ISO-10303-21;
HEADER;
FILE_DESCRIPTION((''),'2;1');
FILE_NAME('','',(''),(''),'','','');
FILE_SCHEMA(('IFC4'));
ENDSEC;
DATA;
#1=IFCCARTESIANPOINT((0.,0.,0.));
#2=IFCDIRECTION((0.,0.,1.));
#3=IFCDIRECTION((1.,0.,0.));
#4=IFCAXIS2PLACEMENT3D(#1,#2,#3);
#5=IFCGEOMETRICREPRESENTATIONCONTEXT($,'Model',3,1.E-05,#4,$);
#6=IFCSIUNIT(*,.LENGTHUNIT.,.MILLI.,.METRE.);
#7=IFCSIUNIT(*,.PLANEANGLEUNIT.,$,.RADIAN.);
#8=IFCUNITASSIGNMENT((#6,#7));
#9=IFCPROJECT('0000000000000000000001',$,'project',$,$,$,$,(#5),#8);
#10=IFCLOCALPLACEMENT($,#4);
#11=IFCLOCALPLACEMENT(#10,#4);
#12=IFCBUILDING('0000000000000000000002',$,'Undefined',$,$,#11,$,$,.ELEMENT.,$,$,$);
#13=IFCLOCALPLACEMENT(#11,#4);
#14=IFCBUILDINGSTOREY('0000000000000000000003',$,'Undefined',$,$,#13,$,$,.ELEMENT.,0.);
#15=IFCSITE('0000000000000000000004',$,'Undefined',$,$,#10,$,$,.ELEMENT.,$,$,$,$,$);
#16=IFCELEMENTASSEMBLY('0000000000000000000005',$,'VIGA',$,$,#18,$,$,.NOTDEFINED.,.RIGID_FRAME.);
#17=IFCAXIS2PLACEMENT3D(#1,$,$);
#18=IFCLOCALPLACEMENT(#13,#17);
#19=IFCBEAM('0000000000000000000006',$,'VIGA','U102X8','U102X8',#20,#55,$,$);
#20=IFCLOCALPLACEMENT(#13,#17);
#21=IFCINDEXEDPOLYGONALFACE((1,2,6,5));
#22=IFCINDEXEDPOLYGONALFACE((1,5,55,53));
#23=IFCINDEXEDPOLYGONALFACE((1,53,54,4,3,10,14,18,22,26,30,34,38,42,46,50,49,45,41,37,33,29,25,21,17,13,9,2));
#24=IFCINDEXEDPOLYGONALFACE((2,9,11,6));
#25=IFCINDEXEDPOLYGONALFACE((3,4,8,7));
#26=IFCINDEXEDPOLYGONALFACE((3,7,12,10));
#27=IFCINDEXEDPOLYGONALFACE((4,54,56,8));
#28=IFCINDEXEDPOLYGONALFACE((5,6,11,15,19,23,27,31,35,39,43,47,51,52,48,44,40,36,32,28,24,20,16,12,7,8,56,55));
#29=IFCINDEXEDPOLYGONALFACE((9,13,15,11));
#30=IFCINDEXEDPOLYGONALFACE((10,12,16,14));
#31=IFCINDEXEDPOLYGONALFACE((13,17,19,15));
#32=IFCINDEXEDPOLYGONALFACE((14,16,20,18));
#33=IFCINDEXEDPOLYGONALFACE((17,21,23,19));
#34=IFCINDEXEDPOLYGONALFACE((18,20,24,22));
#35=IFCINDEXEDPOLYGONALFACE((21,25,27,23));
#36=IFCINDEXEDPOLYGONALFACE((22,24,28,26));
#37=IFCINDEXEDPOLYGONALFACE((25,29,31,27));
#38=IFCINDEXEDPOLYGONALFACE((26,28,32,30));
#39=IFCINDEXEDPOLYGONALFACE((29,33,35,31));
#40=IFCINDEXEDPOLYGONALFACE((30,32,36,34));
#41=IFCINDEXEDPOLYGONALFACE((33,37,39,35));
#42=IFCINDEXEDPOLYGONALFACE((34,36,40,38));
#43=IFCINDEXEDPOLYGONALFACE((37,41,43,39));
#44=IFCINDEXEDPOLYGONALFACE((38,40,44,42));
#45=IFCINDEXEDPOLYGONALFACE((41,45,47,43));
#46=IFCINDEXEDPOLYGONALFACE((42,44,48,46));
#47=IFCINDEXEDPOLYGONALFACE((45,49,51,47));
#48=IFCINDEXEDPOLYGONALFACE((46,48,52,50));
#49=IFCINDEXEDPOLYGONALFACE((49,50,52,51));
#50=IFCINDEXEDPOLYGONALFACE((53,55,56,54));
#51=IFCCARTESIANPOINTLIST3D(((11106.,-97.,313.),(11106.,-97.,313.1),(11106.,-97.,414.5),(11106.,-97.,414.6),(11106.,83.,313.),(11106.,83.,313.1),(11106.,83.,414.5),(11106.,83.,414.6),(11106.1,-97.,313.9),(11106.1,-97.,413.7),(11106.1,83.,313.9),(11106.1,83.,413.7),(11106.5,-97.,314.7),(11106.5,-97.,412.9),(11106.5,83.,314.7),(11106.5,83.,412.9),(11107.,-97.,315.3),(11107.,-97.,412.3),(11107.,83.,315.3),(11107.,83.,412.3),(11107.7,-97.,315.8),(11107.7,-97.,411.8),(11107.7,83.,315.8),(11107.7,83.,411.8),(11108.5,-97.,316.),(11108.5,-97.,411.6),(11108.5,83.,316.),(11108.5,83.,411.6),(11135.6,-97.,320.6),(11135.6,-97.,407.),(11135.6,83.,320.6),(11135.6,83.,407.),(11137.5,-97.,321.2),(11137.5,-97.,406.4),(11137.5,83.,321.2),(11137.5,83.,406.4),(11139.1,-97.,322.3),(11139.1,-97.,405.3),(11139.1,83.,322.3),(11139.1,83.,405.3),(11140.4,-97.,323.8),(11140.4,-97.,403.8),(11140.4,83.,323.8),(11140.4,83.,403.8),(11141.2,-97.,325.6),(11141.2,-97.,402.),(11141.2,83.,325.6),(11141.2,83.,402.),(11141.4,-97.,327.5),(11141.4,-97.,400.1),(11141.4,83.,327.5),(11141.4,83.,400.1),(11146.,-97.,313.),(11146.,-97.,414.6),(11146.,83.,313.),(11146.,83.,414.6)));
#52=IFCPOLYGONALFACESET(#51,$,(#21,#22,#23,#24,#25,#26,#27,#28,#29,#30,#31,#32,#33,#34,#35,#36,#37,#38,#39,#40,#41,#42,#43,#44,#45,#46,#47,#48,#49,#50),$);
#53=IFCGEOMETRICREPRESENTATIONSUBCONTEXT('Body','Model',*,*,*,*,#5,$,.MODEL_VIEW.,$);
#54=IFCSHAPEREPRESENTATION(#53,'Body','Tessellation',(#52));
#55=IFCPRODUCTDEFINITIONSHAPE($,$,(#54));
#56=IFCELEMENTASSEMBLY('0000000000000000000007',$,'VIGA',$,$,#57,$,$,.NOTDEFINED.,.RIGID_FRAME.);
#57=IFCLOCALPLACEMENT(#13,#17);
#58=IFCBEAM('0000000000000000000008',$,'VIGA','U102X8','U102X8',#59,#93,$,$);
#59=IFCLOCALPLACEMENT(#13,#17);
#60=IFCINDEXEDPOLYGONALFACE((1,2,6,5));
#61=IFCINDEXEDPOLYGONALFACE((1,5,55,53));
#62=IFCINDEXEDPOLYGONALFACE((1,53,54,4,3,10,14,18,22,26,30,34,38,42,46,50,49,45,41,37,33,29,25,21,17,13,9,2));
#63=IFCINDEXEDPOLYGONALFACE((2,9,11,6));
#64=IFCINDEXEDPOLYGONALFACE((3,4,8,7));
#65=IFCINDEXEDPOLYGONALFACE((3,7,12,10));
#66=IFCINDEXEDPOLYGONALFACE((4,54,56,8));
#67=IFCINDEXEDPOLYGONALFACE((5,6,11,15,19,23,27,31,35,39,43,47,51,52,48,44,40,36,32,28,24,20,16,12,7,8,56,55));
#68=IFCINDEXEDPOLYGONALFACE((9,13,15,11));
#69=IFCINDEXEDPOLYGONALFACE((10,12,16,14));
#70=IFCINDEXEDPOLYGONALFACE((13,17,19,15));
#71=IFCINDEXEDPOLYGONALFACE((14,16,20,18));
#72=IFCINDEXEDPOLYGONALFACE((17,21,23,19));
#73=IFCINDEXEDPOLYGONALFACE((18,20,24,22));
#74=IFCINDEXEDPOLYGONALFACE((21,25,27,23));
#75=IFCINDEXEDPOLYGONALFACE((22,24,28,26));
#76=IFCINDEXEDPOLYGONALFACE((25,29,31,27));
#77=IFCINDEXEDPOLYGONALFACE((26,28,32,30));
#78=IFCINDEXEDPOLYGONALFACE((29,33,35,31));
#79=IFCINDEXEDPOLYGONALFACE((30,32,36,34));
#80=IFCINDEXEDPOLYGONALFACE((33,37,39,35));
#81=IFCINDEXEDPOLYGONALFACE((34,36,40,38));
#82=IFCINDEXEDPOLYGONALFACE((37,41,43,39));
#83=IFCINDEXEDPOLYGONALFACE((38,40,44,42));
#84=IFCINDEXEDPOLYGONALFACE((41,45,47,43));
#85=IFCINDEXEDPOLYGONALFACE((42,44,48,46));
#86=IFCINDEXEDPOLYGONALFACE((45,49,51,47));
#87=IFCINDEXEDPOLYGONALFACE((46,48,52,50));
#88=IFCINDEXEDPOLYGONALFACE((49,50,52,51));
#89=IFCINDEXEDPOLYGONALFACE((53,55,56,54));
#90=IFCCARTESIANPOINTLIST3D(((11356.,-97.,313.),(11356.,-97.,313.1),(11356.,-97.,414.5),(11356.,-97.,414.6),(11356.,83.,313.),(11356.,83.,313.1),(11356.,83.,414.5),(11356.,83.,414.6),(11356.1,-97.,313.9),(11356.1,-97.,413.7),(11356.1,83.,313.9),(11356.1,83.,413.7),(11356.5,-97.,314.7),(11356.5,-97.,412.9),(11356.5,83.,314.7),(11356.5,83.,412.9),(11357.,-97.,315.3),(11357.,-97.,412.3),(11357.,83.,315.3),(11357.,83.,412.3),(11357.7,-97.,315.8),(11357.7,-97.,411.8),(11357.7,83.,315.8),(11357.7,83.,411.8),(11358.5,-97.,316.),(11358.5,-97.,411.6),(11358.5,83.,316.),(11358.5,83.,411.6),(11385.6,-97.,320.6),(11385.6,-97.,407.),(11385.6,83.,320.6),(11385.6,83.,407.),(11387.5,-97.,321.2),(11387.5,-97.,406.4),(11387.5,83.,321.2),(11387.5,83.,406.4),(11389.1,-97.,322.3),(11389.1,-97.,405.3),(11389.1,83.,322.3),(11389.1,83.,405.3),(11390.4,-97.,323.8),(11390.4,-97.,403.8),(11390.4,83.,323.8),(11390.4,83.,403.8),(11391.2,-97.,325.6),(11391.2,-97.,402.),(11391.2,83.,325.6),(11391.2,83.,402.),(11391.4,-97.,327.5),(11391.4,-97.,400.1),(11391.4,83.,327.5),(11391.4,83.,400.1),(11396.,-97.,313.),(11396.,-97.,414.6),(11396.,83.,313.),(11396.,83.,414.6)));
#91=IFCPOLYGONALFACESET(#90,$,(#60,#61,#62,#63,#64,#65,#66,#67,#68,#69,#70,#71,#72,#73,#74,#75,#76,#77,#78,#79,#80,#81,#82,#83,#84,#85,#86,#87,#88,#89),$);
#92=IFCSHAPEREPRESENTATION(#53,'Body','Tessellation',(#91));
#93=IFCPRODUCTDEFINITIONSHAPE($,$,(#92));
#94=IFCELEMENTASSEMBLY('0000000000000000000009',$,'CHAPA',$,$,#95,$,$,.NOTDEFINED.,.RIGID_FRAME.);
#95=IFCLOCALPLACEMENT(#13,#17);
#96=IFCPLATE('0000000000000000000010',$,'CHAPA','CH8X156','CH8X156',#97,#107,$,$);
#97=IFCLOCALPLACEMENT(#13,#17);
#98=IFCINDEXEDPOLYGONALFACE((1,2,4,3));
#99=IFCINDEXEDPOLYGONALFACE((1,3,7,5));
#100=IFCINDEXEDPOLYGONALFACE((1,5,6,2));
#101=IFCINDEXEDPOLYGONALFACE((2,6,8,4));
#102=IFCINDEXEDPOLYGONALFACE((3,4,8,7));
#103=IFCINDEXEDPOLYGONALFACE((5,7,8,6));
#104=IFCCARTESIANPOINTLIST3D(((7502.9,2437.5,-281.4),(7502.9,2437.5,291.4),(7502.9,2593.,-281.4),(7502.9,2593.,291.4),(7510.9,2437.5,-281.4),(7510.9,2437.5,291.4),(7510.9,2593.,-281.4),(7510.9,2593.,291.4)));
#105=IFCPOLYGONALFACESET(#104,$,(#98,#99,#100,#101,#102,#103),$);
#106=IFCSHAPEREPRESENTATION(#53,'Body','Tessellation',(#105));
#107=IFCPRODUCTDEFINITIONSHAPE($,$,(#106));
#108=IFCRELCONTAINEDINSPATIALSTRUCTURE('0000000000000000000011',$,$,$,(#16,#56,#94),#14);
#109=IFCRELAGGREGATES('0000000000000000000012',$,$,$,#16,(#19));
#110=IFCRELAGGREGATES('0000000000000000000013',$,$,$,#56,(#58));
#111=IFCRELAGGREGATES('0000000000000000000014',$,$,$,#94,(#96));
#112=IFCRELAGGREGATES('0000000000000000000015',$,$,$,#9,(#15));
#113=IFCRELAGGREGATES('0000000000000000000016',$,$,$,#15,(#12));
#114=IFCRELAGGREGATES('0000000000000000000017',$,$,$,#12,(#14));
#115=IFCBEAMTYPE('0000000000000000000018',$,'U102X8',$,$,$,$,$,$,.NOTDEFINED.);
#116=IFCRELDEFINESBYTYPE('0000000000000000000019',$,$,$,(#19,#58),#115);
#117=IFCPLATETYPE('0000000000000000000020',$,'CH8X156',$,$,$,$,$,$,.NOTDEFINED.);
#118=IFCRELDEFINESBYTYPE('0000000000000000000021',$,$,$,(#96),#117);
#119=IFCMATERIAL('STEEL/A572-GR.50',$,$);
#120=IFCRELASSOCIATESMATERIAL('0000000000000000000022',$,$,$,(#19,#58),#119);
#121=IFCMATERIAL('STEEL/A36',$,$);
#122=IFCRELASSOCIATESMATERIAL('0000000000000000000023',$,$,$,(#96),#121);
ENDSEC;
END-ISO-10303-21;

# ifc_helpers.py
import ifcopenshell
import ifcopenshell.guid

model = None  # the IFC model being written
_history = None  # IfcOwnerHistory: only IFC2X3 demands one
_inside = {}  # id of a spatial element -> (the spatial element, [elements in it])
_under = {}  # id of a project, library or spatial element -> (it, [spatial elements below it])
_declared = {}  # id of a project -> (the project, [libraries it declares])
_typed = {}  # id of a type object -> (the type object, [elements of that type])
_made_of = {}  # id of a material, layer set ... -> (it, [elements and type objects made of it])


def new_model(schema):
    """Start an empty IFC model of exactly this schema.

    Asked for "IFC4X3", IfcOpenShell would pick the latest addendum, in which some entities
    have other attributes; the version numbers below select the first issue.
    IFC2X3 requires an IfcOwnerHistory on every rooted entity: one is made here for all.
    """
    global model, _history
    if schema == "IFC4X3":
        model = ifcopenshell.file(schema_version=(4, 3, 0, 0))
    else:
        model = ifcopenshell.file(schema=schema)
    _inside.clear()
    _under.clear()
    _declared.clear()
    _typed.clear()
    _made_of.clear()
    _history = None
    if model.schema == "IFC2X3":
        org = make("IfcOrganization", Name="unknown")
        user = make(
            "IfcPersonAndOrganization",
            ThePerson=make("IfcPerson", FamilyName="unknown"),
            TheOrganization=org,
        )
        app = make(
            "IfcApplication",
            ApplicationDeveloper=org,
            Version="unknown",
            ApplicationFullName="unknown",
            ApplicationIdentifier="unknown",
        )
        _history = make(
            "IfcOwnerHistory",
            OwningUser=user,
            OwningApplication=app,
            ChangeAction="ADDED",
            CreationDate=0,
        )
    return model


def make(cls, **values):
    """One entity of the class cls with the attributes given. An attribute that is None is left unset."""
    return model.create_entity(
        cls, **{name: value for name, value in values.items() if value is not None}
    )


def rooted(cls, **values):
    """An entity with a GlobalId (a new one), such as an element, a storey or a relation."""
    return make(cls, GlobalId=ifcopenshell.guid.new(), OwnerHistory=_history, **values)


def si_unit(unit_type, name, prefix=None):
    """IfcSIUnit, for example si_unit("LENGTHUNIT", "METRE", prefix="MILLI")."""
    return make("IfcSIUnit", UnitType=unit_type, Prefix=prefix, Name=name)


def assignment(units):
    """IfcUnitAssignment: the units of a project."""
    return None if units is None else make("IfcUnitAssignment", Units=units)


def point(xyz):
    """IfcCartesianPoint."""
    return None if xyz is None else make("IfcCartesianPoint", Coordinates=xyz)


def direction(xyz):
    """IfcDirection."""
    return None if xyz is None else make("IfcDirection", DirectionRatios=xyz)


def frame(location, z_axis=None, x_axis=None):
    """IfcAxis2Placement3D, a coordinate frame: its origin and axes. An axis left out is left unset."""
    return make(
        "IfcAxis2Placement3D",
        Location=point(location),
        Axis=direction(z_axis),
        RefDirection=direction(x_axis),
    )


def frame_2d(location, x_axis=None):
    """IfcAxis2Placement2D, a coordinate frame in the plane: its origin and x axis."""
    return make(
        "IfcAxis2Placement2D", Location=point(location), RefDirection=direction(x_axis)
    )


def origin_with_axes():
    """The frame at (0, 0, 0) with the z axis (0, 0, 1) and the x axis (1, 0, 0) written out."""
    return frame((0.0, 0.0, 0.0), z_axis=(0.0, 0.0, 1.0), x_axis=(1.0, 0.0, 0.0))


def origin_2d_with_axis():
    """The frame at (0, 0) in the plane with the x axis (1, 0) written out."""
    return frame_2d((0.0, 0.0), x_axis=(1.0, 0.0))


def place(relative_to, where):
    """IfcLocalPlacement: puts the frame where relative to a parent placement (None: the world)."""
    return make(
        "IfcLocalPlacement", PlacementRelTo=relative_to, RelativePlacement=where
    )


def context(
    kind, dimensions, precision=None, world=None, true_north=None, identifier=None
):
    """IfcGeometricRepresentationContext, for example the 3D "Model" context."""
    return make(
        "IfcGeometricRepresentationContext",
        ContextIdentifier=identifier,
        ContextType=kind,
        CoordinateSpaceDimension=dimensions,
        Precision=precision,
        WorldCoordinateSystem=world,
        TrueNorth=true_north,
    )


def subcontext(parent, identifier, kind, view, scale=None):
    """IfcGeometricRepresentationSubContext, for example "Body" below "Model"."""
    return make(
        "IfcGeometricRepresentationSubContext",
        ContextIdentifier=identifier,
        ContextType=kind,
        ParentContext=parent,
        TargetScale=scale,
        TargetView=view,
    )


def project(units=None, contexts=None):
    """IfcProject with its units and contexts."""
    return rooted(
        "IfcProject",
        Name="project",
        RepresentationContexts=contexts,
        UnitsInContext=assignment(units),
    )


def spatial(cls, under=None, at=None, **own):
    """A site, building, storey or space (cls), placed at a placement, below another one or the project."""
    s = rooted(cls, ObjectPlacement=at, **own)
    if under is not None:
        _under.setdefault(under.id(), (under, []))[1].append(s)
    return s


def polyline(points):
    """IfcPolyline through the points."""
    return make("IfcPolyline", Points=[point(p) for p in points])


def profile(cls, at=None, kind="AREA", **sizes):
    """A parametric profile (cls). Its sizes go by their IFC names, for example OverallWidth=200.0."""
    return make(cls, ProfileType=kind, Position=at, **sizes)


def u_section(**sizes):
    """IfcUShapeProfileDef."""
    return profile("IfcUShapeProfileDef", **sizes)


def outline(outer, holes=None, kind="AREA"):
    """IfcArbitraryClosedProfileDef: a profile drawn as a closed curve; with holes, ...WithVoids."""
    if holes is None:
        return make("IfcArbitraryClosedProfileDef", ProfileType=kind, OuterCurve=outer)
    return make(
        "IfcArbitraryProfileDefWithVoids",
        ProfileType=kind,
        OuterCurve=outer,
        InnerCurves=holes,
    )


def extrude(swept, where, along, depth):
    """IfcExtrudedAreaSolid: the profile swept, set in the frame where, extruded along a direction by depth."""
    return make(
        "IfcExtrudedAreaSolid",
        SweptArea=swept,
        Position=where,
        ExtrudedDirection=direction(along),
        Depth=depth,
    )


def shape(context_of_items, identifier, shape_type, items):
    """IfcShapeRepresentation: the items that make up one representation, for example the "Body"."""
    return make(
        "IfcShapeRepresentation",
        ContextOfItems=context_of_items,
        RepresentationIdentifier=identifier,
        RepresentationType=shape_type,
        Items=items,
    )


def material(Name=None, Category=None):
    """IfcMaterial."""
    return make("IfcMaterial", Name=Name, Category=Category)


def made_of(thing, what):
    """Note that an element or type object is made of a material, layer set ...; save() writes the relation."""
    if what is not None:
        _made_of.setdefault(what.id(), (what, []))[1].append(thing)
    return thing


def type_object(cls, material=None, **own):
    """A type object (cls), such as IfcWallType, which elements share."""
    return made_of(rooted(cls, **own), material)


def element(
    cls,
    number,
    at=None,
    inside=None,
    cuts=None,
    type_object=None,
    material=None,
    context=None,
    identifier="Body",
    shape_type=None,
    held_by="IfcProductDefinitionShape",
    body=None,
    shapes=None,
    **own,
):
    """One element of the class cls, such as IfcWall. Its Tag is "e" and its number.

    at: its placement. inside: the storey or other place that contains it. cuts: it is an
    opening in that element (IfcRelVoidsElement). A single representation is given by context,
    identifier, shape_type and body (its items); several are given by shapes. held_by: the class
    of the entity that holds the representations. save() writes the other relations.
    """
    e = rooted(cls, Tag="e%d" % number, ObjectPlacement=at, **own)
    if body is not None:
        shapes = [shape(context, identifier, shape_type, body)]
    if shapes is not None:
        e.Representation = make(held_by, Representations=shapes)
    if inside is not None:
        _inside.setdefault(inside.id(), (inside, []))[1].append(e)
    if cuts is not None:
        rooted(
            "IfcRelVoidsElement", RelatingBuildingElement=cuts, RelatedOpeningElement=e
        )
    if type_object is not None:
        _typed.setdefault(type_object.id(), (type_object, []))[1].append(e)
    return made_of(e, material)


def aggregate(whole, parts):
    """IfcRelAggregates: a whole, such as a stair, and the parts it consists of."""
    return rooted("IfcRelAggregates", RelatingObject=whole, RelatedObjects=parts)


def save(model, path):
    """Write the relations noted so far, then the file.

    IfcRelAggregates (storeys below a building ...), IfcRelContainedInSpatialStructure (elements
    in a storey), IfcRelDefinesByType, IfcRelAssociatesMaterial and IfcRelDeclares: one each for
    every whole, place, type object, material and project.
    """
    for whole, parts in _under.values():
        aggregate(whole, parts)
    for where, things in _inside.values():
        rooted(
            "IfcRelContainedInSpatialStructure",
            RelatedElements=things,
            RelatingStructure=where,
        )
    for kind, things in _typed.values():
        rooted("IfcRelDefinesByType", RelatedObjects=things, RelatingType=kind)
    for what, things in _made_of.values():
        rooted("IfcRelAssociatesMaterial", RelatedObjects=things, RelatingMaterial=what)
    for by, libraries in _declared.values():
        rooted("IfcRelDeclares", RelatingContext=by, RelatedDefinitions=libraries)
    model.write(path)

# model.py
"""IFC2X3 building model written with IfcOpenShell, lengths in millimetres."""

from ifc_helpers import new_model, si_unit, frame, origin_with_axes, origin_2d_with_axis, place, context, subcontext, project, spatial, polyline, u_section, outline, extrude, material, type_object, element, aggregate, save


model = new_model("IFC2X3")

# Units and contexts
model_context = context("Model", 3, precision=1e-05, world=origin_with_axes())
body_context = subcontext(model_context, "Body", "Model", "MODEL_VIEW")
ifc_project = project(units=[si_unit("LENGTHUNIT", "METRE", prefix="MILLI"), si_unit("PLANEANGLEUNIT", "RADIAN")], contexts=[model_context])

# Site, building, storey
site_placement = place(None, origin_with_axes())
site = spatial("IfcSite", under=ifc_project, at=site_placement, Name="Undefined", CompositionType="ELEMENT")
building_placement = place(site_placement, origin_with_axes())
building = spatial("IfcBuilding", under=site, at=building_placement, Name="Undefined", CompositionType="ELEMENT")
storey_placement = place(building_placement, origin_with_axes())
storey = spatial("IfcBuildingStorey", under=building, at=storey_placement, Name="Undefined", CompositionType="ELEMENT", Elevation=0.0)

# Element assemblies, beams
ifc_material_1 = material(Name="STEEL/A572-GR.50")
beam_type = type_object("IfcBeamType", Name="U102X8", PredefinedType="NOTDEFINED")
assembly_1_placement = place(storey_placement, origin_with_axes())
assembly_1 = element("IfcElementAssembly", 1, at=assembly_1_placement, inside=storey, Name="VIGA", AssemblyPlace="NOTDEFINED", PredefinedType="RIGID_FRAME")
beam_1_placement = place(assembly_1_placement, frame((11126.0, 83.0, 363.8), z_axis=(0.0, 0.0, 1.0), x_axis=(0.0, -1.0, 0.0)))
beam_1 = element("IfcBeam", 2, at=beam_1_placement, type_object=beam_type, material=ifc_material_1, Name="VIGA", Description="U102X8", ObjectType="U102X8", context=body_context, shape_type="SweptSolid", body=[
    extrude(u_section(Depth=101.6, FlangeWidth=40.0, WebThickness=4.6, FlangeThickness=6.0, FilletRadius=7.0, EdgeRadius=3.0, FlangeSlope=0.16839, at=origin_2d_with_axis()), frame((180.0, 0.0, 0.0), z_axis=(-1.0, 0.0, 0.0), x_axis=(0.0, -1.0, 0.0)), (0.0, 0.0, 1.0), 180.0),
])
aggregate(assembly_1, [beam_1])
assembly_2_placement = place(storey_placement, origin_with_axes())
assembly_2 = element("IfcElementAssembly", 3, at=assembly_2_placement, inside=storey, Name="VIGA", AssemblyPlace="NOTDEFINED", PredefinedType="RIGID_FRAME")
beam_2_placement = place(assembly_2_placement, frame((11376.0, 83.0, 363.8), z_axis=(0.0, 0.0, 1.0), x_axis=(0.0, -1.0, 0.0)))
beam_2 = element("IfcBeam", 4, at=beam_2_placement, type_object=beam_type, material=ifc_material_1, Name="VIGA", Description="U102X8", ObjectType="U102X8", context=body_context, shape_type="SweptSolid", body=[
    extrude(u_section(Depth=101.6, FlangeWidth=40.0, WebThickness=4.6, FlangeThickness=6.0, FilletRadius=7.0, EdgeRadius=3.0, FlangeSlope=0.16839, at=origin_2d_with_axis()), frame((180.0, 0.0, 0.0), z_axis=(-1.0, 0.0, 0.0), x_axis=(0.0, -1.0, 0.0)), (0.0, 0.0, 1.0), 180.0),
])
aggregate(assembly_2, [beam_2])

# Element assembly, plate
assembly_3_placement = place(storey_placement, origin_with_axes())
assembly_3 = element("IfcElementAssembly", 5, at=assembly_3_placement, inside=storey, Name="CHAPA", AssemblyPlace="NOTDEFINED", PredefinedType="RIGID_FRAME")
ifc_material_2 = material(Name="STEEL/A36")
plate_type = type_object("IfcPlateType", Name="CH8X156", PredefinedType="NOTDEFINED")
plate_placement = place(assembly_3_placement, frame((7506.9, 2593.0, 291.4), z_axis=(1.0, 0.0, 0.0), x_axis=(0.0, -1.0, 0.0)))
plate = element("IfcPlate", 6, at=plate_placement, type_object=plate_type, material=ifc_material_2, Name="CHAPA", Description="CH8X156", ObjectType="CH8X156", context=body_context, shape_type="SweptSolid", body=[
    extrude(outline(polyline([(0.0, 0.0), (155.5, 0.0), (155.5, 572.8), (0.0, 572.8), (0.0, 0.0)])), frame((0.0, 0.0, -4.0), z_axis=(0.0, 0.0, 1.0), x_axis=(1.0, 0.0, 0.0)), (0.0, 0.0, 1.0), 8.0),
])
aggregate(assembly_3, [plate])

save(model, "model.ifc")
